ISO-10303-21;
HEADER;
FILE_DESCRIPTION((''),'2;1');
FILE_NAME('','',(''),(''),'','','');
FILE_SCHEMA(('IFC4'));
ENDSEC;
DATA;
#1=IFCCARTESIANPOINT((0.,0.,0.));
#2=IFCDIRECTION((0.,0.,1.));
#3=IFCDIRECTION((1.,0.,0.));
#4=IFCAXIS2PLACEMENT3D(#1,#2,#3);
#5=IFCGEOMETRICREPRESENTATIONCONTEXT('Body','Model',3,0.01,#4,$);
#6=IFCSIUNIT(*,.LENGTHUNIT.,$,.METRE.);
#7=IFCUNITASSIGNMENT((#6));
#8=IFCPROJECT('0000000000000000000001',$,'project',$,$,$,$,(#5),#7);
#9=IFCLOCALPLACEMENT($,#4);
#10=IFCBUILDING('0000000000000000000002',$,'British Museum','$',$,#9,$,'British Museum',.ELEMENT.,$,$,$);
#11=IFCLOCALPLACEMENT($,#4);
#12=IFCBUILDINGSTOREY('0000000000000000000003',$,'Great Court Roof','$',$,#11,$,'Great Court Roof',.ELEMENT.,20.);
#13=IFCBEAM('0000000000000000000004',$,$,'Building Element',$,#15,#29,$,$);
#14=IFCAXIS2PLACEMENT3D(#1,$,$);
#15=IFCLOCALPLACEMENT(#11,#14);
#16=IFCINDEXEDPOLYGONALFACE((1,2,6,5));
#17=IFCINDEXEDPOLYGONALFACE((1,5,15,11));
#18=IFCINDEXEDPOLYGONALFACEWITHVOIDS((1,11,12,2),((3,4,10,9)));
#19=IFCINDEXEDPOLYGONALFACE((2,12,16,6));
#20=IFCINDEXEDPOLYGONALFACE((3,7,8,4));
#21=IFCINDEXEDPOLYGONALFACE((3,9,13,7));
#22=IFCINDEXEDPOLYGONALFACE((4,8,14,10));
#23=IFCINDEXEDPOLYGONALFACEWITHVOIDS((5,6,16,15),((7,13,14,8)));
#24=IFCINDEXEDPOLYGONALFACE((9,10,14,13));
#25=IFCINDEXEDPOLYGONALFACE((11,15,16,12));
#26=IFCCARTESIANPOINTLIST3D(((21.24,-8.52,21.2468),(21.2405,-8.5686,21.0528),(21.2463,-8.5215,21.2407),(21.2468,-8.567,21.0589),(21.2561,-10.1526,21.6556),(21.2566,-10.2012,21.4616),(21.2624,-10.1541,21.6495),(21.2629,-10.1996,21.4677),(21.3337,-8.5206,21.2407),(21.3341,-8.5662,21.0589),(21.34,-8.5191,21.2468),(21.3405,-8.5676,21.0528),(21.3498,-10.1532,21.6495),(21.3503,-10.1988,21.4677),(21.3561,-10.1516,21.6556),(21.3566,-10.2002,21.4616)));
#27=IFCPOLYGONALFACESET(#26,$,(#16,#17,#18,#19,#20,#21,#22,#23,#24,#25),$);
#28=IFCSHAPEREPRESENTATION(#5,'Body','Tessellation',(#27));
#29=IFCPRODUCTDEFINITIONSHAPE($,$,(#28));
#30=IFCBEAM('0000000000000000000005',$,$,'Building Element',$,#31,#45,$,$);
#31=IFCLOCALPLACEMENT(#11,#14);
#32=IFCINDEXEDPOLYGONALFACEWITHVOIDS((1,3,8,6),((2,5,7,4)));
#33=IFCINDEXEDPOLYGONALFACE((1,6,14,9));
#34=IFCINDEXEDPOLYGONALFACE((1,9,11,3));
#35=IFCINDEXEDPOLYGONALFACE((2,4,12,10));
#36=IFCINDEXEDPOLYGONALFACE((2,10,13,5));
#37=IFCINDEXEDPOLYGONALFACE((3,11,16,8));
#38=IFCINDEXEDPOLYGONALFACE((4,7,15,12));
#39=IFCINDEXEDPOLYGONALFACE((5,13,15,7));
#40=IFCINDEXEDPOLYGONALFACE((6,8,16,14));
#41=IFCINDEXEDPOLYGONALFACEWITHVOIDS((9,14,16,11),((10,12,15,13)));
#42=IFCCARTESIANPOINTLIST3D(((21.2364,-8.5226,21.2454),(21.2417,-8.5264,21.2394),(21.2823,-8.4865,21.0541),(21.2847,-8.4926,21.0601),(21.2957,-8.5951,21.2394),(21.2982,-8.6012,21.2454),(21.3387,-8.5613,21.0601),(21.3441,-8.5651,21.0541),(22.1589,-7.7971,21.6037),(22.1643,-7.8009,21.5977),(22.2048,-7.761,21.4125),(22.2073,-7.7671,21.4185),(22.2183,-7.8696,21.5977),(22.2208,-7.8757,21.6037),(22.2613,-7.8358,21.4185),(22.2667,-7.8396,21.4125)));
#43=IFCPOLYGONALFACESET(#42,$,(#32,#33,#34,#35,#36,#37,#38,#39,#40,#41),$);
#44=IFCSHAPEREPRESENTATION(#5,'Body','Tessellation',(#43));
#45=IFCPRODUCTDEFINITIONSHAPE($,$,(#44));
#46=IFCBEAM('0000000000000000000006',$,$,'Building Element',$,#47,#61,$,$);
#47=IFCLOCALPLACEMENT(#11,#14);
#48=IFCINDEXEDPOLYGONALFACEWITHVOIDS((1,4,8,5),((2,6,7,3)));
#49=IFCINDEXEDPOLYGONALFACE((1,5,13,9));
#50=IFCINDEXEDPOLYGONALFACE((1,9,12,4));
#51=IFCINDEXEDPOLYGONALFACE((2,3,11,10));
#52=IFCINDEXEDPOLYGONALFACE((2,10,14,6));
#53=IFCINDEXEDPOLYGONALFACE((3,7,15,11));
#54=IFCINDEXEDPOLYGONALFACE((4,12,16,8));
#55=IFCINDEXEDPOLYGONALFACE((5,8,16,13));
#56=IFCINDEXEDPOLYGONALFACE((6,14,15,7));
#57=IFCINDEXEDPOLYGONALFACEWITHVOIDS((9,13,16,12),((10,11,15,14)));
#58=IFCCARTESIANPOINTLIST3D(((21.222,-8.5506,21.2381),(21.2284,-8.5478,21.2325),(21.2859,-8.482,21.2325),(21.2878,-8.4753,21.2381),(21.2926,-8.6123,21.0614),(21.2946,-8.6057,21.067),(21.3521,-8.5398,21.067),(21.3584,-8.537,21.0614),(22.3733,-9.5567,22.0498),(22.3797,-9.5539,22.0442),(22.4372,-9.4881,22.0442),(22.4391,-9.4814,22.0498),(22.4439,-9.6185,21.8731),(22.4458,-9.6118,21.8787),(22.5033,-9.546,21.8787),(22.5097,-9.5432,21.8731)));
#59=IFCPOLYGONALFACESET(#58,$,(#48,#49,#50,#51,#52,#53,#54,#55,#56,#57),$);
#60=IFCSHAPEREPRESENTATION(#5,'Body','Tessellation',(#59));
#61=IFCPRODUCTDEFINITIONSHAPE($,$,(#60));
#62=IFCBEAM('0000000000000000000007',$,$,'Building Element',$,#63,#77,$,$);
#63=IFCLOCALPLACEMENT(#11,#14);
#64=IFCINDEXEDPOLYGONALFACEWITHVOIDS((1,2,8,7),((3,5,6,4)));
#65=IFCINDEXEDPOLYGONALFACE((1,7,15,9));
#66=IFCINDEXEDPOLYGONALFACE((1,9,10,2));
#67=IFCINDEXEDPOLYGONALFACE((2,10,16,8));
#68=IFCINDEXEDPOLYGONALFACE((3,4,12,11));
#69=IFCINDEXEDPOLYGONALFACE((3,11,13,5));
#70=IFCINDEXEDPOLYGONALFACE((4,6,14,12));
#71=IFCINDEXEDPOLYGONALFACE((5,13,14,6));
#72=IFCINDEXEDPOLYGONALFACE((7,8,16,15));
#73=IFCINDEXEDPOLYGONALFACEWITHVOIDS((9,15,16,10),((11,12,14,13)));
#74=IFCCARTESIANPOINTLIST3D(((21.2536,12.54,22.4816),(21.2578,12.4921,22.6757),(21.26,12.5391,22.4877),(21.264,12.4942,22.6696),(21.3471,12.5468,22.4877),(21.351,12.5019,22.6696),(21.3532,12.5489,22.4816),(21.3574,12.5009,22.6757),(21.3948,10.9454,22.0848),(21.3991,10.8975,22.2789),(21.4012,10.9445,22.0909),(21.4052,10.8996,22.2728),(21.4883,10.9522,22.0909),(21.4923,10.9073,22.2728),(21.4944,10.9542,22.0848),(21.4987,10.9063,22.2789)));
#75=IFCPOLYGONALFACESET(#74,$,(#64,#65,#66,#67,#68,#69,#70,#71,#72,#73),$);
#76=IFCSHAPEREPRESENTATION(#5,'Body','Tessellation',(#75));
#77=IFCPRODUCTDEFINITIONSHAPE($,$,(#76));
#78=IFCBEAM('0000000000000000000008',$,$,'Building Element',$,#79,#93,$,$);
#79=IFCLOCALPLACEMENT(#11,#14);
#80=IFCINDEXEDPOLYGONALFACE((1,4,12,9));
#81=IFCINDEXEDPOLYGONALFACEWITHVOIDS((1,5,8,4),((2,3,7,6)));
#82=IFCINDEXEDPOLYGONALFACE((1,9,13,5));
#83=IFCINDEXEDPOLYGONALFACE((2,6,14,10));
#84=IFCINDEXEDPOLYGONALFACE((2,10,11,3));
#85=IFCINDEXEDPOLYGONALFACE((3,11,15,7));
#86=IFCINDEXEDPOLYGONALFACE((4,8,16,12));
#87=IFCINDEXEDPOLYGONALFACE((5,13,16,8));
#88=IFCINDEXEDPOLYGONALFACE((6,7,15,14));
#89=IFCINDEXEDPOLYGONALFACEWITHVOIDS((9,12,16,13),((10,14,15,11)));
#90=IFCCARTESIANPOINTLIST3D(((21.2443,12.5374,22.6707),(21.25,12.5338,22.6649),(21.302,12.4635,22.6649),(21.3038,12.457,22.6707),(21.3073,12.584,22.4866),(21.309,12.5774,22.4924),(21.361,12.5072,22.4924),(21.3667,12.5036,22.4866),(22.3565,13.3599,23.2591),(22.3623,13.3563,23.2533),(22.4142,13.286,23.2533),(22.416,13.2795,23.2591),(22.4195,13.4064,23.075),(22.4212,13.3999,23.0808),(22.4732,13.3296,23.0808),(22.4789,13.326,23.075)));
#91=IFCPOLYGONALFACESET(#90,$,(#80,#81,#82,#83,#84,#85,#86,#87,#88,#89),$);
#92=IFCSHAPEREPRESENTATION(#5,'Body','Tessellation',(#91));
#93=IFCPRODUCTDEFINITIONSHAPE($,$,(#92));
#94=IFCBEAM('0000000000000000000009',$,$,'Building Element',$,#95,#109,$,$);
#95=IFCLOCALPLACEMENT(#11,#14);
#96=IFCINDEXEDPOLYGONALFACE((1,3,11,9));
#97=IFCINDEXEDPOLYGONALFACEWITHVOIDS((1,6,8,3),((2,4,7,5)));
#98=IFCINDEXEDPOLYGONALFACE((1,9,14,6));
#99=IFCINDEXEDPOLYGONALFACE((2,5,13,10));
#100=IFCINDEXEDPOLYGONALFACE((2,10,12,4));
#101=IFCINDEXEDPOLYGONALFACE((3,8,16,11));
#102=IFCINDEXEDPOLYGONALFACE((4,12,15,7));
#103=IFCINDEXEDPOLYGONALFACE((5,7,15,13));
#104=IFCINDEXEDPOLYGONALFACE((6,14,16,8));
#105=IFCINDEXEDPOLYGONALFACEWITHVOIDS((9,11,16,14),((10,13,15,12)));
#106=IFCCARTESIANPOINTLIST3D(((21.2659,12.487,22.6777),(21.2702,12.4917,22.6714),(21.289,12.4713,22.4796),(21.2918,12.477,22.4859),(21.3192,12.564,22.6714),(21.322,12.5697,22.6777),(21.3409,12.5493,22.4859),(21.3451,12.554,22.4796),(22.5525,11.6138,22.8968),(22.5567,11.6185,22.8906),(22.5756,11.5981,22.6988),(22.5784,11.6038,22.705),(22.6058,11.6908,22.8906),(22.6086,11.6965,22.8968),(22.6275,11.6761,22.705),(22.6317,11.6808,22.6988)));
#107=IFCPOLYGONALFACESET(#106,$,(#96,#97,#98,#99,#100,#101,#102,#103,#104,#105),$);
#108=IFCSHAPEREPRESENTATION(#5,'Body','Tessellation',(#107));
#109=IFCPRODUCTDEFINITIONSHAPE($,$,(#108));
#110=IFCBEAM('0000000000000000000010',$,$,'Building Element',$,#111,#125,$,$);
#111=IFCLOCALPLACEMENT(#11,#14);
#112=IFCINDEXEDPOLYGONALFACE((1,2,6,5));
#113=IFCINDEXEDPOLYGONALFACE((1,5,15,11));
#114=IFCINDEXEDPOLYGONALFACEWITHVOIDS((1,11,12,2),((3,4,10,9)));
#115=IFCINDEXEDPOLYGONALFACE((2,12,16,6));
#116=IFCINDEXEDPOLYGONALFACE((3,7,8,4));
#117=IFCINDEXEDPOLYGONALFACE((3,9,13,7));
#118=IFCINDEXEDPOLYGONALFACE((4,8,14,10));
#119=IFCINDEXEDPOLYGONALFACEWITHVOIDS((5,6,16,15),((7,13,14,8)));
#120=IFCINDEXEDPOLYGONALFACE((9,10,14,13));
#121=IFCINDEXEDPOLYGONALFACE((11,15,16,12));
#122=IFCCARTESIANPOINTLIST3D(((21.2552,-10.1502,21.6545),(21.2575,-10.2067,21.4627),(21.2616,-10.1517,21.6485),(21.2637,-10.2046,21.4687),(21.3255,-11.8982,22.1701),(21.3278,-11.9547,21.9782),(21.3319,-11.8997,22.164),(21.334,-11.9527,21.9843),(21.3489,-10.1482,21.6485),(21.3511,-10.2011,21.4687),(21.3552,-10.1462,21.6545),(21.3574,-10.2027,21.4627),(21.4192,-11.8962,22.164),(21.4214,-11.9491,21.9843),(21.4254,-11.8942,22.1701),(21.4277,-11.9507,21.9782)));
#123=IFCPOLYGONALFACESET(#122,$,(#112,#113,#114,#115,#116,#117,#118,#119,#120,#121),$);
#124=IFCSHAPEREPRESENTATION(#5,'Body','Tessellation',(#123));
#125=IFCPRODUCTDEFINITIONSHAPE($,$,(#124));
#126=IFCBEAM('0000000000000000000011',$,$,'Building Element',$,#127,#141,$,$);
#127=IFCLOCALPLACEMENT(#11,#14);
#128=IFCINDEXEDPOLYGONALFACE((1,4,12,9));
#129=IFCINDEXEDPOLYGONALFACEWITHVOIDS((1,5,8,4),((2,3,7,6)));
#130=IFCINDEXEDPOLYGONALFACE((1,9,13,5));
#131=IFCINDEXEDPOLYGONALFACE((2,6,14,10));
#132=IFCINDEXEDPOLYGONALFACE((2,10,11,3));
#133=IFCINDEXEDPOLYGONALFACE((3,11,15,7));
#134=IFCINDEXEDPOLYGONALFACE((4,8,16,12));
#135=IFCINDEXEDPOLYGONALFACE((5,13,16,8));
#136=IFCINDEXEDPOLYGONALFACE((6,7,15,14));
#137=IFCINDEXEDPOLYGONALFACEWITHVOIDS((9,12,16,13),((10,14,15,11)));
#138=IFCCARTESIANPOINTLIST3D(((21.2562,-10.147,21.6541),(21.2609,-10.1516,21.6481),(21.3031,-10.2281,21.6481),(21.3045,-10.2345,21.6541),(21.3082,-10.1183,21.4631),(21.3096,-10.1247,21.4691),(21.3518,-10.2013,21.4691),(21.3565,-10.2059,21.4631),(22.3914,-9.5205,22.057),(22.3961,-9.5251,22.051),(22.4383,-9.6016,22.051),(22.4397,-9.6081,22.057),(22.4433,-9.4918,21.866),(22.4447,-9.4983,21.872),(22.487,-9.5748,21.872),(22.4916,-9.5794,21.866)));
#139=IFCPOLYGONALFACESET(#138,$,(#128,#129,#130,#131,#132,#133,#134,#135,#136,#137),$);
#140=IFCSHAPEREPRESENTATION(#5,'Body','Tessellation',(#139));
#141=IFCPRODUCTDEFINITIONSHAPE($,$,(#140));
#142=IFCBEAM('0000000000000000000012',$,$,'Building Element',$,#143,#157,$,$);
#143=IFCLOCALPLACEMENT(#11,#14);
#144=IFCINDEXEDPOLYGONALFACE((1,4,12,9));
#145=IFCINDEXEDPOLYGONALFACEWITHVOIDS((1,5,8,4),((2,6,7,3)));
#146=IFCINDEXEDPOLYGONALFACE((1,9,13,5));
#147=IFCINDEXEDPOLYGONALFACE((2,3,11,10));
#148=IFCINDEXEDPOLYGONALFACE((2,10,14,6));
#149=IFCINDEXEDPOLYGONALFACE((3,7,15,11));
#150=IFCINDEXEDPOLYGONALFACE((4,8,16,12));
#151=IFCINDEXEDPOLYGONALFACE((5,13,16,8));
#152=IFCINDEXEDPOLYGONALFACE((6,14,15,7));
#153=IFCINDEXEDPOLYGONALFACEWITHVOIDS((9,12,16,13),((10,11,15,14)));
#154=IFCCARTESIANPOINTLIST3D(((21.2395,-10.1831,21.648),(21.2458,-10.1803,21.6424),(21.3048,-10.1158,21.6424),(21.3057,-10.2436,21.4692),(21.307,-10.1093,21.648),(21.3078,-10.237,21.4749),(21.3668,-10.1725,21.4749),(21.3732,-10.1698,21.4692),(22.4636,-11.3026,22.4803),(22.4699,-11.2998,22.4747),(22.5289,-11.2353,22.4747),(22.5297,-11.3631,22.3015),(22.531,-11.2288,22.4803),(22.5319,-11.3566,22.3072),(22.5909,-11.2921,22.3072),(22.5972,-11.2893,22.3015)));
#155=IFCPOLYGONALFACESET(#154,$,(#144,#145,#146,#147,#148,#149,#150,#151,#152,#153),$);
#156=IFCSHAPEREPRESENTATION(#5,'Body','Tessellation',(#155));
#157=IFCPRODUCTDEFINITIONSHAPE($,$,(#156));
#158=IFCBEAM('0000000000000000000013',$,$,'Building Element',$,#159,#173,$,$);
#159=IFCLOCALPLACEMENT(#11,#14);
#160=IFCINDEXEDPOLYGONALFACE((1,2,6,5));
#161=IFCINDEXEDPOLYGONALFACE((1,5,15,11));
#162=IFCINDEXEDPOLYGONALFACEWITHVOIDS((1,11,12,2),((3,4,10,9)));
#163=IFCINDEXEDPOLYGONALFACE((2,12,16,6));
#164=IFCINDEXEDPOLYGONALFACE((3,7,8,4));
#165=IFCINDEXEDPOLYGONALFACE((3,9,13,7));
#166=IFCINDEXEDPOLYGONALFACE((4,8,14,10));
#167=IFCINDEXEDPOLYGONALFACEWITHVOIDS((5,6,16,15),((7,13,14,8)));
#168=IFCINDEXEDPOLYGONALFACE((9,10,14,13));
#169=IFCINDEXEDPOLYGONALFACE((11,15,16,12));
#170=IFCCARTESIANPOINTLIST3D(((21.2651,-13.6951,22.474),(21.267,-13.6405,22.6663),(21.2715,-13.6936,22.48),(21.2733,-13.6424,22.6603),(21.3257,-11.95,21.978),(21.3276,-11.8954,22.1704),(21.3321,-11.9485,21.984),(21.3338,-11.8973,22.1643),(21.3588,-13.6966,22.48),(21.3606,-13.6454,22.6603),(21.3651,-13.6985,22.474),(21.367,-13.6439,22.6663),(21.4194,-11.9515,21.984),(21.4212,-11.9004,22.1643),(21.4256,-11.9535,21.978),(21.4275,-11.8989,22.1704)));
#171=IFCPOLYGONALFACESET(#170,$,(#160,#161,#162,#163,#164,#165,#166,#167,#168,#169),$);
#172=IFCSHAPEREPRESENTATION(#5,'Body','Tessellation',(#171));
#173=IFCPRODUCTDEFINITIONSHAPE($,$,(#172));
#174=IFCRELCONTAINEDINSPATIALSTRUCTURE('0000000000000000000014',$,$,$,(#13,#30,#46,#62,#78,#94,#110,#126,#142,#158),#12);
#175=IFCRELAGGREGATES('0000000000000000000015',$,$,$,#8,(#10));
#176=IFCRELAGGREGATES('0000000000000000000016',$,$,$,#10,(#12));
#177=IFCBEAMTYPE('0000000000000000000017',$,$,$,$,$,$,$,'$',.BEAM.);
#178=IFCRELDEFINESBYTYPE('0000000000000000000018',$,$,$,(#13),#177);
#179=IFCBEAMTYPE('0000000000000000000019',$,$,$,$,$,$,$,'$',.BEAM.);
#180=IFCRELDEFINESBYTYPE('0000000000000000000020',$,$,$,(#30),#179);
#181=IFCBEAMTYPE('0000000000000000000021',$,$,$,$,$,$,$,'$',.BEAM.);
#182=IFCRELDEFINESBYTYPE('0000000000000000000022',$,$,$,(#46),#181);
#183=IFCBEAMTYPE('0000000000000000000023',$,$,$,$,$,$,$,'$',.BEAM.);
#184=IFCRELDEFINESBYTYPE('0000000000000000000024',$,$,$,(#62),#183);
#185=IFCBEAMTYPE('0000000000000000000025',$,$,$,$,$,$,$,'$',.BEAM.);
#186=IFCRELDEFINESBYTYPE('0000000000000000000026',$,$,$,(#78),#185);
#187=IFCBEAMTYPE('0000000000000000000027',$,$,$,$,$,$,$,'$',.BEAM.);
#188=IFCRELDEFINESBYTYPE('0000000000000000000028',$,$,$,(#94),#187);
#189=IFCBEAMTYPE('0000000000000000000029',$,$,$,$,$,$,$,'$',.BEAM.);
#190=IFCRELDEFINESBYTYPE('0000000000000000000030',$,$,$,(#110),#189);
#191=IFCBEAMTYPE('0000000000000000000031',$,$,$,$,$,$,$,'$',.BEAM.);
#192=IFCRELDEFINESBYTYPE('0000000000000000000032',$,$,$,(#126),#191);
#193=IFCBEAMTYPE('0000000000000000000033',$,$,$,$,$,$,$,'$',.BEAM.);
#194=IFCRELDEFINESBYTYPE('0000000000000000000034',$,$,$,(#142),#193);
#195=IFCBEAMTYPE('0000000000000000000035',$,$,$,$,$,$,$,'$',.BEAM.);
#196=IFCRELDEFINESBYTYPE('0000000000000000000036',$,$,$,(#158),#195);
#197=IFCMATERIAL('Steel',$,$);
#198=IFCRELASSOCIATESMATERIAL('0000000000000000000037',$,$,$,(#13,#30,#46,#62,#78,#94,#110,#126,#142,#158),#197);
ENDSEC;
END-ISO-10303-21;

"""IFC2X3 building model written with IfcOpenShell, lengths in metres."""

from ifc_helpers import new_model, si_unit, frame, origin_with_axes, origin_2d, place, context, project, spatial, hollow_rectangle, extrude, material, type_object, element, save


model = new_model("IFC2X3")

# Units and contexts
model_context = context("Model", 3, precision=0.01, world=origin_with_axes(), identifier="Body")
ifc_project = project(units=[si_unit("LENGTHUNIT", "METRE")], contexts=[model_context])

# Building, storey
building_placement = place(None, origin_with_axes())
building = spatial("IfcBuilding", under=ifc_project, at=building_placement, Name="British Museum", Description="$", LongName="British Museum", CompositionType="ELEMENT")
storey_placement = place(None, origin_with_axes())
storey = spatial("IfcBuildingStorey", under=building, at=storey_placement, Name="Great Court Roof", Description="$", LongName="Great Court Roof", CompositionType="ELEMENT", Elevation=20.0)

# Beams
ifc_material = material(Name="Steel")
beam_type_1 = type_object("IfcBeamType", ElementType="$", PredefinedType="BEAM")
beam_1_placement = place(None, origin_with_axes())
element("IfcBeam", 1, at=beam_1_placement, inside=storey, type_object=beam_type_1, material=ifc_material, Description="Building Element", context=model_context, shape_type="SweptSolid", body=[
    extrude(hollow_rectangle(XDim=0.1, YDim=0.2, WallThickness=0.0063, InnerFilletRadius=-0.0063, OuterFilletRadius=0.0, at=origin_2d()), frame((21.2902, -8.5438, 21.1498), z_axis=(0.009572, -0.969999, 0.24292), x_axis=(0.999951, 0.009867, 0.0)), (0.0, 0.0, 1.0), 1.6831),
])
beam_type_2 = type_object("IfcBeamType", ElementType="$", PredefinedType="BEAM")
beam_2_placement = place(None, origin_with_axes())
element("IfcBeam", 2, at=beam_2_placement, inside=storey, type_object=beam_type_2, material=ifc_material, Description="Building Element", context=model_context, shape_type="SweptSolid", body=[
    extrude(hollow_rectangle(XDim=0.1, YDim=0.2, WallThickness=0.0063, InnerFilletRadius=-0.0063, OuterFilletRadius=0.0, at=origin_2d()), frame((21.2902, -8.5438, 21.1498), z_axis=(0.751805, 0.591204, 0.292007), x_axis=(-0.618145, 0.786064, 0.0)), (0.0, 0.0, 1.0), 1.2272),
])
beam_type_3 = type_object("IfcBeamType", ElementType="$", PredefinedType="BEAM")
beam_3_placement = place(None, origin_with_axes())
element("IfcBeam", 3, at=beam_3_placement, inside=storey, type_object=beam_type_3, material=ifc_material, Description="Building Element", context=model_context, shape_type="SweptSolid", body=[
    extrude(hollow_rectangle(XDim=0.1, YDim=0.2, WallThickness=0.0063, InnerFilletRadius=-0.0063, OuterFilletRadius=0.0, at=origin_2d()), frame((21.2902, -8.5438, 21.1498), z_axis=(0.665073, -0.581209, 0.468907), x_axis=(0.658037, 0.752986, 0.0)), (0.0, 0.0, 1.0), 1.7311),
])
beam_type_4 = type_object("IfcBeamType", ElementType="$", PredefinedType="BEAM")
beam_4_placement = place(None, origin_with_axes())
element("IfcBeam", 4, at=beam_4_placement, inside=storey, type_object=beam_type_4, material=ifc_material, Description="Building Element", context=model_context, shape_type="SweptSolid", body=[
    extrude(hollow_rectangle(XDim=0.1, YDim=0.2, WallThickness=0.0063, InnerFilletRadius=-0.0063, OuterFilletRadius=0.0, at=origin_2d()), frame((21.3055, 12.5205, 22.5787), z_axis=(0.085621, -0.966843, -0.240588), x_axis=(0.996102, 0.088212, 0.0)), (0.0, 0.0, 1.0), 1.6493),
])
beam_type_5 = type_object("IfcBeamType", ElementType="$", PredefinedType="BEAM")
beam_5_placement = place(None, origin_with_axes())
element("IfcBeam", 5, at=beam_5_placement, inside=storey, type_object=beam_type_5, material=ifc_material, Description="Building Element", context=model_context, shape_type="SweptSolid", body=[
    extrude(hollow_rectangle(XDim=0.1, YDim=0.2, WallThickness=0.0063, InnerFilletRadius=-0.0063, OuterFilletRadius=0.0, at=origin_2d()), frame((21.3055, 12.5205, 22.5787), z_axis=(0.739891, 0.547121, 0.391433), x_axis=(-0.594564, 0.804049, 0.0)), (0.0, 0.0, 1.0), 1.5032),
])
beam_type_6 = type_object("IfcBeamType", ElementType="$", PredefinedType="BEAM")
beam_6_placement = place(None, origin_with_axes())
element("IfcBeam", 6, at=beam_6_placement, inside=storey, type_object=beam_type_6, material=ifc_material, Description="Building Element", context=model_context, shape_type="SweptSolid", body=[
    extrude(hollow_rectangle(XDim=0.1, YDim=0.2, WallThickness=0.0063, InnerFilletRadius=-0.0063, OuterFilletRadius=0.0, at=origin_2d()), frame((21.3055, 12.5205, 22.5787), z_axis=(0.81933, -0.556078, 0.139554), x_axis=(0.561573, 0.827427, 0.0)), (0.0, 0.0, 1.0), 1.5703),
])
beam_type_7 = type_object("IfcBeamType", ElementType="$", PredefinedType="BEAM")
beam_7_placement = place(None, origin_with_axes())
element("IfcBeam", 7, at=beam_7_placement, inside=storey, type_object=beam_type_7, material=ifc_material, Description="Building Element", context=model_context, shape_type="SweptSolid", body=[
    extrude(hollow_rectangle(XDim=0.1, YDim=0.2, WallThickness=0.0063, InnerFilletRadius=-0.0063, OuterFilletRadius=0.0, at=origin_2d()), frame((21.3063, -10.1764, 21.5586), z_axis=(0.03854, -0.95844, 0.28268), x_axis=(0.999193, 0.040178, 0.0)), (0.0, 0.0, 1.0), 1.8238),
])
beam_type_8 = type_object("IfcBeamType", ElementType="$", PredefinedType="BEAM")
beam_8_placement = place(None, origin_with_axes())
element("IfcBeam", 8, at=beam_8_placement, inside=storey, type_object=beam_type_8, material=ifc_material, Description="Building Element", context=model_context, shape_type="SweptSolid", body=[
    extrude(hollow_rectangle(XDim=0.1, YDim=0.2, WallThickness=0.0063, InnerFilletRadius=-0.0063, OuterFilletRadius=0.0, at=origin_2d()), frame((21.3063, -10.1764, 21.5586), z_axis=(0.836093, 0.461419, 0.296716), x_axis=(-0.483179, 0.875522, 0.0)), (0.0, 0.0, 1.0), 1.3577),
])
beam_type_9 = type_object("IfcBeamType", ElementType="$", PredefinedType="BEAM")
beam_9_placement = place(None, origin_with_axes())
element("IfcBeam", 9, at=beam_9_placement, inside=storey, type_object=beam_type_9, material=ifc_material, Description="Building Element", context=model_context, shape_type="SweptSolid", body=[
    extrude(hollow_rectangle(XDim=0.1, YDim=0.2, WallThickness=0.0063, InnerFilletRadius=-0.0063, OuterFilletRadius=0.0, at=origin_2d()), frame((21.3063, -10.1764, 21.5586), z_axis=(0.659548, -0.603225, 0.44846), x_axis=(0.674897, 0.737912, 0.0)), (0.0, 0.0, 1.0), 1.8559),
])
beam_type_10 = type_object("IfcBeamType", ElementType="$", PredefinedType="BEAM")
beam_10_placement = place(None, origin_with_axes())
element("IfcBeam", 10, at=beam_10_placement, inside=storey, type_object=beam_type_10, material=ifc_material, Description="Building Element", context=model_context, shape_type="SweptSolid", body=[
    extrude(hollow_rectangle(XDim=0.1, YDim=0.2, WallThickness=0.0063, InnerFilletRadius=-0.0063, OuterFilletRadius=0.0, at=origin_2d()), frame((21.316, -13.6695, 22.5701), z_axis=(0.033372, 0.961368, -0.273237), x_axis=(-0.999398, 0.034693, 0.0)), (0.0, 0.0, 1.0), 1.8152),
])

save(model, "model.ifc")
